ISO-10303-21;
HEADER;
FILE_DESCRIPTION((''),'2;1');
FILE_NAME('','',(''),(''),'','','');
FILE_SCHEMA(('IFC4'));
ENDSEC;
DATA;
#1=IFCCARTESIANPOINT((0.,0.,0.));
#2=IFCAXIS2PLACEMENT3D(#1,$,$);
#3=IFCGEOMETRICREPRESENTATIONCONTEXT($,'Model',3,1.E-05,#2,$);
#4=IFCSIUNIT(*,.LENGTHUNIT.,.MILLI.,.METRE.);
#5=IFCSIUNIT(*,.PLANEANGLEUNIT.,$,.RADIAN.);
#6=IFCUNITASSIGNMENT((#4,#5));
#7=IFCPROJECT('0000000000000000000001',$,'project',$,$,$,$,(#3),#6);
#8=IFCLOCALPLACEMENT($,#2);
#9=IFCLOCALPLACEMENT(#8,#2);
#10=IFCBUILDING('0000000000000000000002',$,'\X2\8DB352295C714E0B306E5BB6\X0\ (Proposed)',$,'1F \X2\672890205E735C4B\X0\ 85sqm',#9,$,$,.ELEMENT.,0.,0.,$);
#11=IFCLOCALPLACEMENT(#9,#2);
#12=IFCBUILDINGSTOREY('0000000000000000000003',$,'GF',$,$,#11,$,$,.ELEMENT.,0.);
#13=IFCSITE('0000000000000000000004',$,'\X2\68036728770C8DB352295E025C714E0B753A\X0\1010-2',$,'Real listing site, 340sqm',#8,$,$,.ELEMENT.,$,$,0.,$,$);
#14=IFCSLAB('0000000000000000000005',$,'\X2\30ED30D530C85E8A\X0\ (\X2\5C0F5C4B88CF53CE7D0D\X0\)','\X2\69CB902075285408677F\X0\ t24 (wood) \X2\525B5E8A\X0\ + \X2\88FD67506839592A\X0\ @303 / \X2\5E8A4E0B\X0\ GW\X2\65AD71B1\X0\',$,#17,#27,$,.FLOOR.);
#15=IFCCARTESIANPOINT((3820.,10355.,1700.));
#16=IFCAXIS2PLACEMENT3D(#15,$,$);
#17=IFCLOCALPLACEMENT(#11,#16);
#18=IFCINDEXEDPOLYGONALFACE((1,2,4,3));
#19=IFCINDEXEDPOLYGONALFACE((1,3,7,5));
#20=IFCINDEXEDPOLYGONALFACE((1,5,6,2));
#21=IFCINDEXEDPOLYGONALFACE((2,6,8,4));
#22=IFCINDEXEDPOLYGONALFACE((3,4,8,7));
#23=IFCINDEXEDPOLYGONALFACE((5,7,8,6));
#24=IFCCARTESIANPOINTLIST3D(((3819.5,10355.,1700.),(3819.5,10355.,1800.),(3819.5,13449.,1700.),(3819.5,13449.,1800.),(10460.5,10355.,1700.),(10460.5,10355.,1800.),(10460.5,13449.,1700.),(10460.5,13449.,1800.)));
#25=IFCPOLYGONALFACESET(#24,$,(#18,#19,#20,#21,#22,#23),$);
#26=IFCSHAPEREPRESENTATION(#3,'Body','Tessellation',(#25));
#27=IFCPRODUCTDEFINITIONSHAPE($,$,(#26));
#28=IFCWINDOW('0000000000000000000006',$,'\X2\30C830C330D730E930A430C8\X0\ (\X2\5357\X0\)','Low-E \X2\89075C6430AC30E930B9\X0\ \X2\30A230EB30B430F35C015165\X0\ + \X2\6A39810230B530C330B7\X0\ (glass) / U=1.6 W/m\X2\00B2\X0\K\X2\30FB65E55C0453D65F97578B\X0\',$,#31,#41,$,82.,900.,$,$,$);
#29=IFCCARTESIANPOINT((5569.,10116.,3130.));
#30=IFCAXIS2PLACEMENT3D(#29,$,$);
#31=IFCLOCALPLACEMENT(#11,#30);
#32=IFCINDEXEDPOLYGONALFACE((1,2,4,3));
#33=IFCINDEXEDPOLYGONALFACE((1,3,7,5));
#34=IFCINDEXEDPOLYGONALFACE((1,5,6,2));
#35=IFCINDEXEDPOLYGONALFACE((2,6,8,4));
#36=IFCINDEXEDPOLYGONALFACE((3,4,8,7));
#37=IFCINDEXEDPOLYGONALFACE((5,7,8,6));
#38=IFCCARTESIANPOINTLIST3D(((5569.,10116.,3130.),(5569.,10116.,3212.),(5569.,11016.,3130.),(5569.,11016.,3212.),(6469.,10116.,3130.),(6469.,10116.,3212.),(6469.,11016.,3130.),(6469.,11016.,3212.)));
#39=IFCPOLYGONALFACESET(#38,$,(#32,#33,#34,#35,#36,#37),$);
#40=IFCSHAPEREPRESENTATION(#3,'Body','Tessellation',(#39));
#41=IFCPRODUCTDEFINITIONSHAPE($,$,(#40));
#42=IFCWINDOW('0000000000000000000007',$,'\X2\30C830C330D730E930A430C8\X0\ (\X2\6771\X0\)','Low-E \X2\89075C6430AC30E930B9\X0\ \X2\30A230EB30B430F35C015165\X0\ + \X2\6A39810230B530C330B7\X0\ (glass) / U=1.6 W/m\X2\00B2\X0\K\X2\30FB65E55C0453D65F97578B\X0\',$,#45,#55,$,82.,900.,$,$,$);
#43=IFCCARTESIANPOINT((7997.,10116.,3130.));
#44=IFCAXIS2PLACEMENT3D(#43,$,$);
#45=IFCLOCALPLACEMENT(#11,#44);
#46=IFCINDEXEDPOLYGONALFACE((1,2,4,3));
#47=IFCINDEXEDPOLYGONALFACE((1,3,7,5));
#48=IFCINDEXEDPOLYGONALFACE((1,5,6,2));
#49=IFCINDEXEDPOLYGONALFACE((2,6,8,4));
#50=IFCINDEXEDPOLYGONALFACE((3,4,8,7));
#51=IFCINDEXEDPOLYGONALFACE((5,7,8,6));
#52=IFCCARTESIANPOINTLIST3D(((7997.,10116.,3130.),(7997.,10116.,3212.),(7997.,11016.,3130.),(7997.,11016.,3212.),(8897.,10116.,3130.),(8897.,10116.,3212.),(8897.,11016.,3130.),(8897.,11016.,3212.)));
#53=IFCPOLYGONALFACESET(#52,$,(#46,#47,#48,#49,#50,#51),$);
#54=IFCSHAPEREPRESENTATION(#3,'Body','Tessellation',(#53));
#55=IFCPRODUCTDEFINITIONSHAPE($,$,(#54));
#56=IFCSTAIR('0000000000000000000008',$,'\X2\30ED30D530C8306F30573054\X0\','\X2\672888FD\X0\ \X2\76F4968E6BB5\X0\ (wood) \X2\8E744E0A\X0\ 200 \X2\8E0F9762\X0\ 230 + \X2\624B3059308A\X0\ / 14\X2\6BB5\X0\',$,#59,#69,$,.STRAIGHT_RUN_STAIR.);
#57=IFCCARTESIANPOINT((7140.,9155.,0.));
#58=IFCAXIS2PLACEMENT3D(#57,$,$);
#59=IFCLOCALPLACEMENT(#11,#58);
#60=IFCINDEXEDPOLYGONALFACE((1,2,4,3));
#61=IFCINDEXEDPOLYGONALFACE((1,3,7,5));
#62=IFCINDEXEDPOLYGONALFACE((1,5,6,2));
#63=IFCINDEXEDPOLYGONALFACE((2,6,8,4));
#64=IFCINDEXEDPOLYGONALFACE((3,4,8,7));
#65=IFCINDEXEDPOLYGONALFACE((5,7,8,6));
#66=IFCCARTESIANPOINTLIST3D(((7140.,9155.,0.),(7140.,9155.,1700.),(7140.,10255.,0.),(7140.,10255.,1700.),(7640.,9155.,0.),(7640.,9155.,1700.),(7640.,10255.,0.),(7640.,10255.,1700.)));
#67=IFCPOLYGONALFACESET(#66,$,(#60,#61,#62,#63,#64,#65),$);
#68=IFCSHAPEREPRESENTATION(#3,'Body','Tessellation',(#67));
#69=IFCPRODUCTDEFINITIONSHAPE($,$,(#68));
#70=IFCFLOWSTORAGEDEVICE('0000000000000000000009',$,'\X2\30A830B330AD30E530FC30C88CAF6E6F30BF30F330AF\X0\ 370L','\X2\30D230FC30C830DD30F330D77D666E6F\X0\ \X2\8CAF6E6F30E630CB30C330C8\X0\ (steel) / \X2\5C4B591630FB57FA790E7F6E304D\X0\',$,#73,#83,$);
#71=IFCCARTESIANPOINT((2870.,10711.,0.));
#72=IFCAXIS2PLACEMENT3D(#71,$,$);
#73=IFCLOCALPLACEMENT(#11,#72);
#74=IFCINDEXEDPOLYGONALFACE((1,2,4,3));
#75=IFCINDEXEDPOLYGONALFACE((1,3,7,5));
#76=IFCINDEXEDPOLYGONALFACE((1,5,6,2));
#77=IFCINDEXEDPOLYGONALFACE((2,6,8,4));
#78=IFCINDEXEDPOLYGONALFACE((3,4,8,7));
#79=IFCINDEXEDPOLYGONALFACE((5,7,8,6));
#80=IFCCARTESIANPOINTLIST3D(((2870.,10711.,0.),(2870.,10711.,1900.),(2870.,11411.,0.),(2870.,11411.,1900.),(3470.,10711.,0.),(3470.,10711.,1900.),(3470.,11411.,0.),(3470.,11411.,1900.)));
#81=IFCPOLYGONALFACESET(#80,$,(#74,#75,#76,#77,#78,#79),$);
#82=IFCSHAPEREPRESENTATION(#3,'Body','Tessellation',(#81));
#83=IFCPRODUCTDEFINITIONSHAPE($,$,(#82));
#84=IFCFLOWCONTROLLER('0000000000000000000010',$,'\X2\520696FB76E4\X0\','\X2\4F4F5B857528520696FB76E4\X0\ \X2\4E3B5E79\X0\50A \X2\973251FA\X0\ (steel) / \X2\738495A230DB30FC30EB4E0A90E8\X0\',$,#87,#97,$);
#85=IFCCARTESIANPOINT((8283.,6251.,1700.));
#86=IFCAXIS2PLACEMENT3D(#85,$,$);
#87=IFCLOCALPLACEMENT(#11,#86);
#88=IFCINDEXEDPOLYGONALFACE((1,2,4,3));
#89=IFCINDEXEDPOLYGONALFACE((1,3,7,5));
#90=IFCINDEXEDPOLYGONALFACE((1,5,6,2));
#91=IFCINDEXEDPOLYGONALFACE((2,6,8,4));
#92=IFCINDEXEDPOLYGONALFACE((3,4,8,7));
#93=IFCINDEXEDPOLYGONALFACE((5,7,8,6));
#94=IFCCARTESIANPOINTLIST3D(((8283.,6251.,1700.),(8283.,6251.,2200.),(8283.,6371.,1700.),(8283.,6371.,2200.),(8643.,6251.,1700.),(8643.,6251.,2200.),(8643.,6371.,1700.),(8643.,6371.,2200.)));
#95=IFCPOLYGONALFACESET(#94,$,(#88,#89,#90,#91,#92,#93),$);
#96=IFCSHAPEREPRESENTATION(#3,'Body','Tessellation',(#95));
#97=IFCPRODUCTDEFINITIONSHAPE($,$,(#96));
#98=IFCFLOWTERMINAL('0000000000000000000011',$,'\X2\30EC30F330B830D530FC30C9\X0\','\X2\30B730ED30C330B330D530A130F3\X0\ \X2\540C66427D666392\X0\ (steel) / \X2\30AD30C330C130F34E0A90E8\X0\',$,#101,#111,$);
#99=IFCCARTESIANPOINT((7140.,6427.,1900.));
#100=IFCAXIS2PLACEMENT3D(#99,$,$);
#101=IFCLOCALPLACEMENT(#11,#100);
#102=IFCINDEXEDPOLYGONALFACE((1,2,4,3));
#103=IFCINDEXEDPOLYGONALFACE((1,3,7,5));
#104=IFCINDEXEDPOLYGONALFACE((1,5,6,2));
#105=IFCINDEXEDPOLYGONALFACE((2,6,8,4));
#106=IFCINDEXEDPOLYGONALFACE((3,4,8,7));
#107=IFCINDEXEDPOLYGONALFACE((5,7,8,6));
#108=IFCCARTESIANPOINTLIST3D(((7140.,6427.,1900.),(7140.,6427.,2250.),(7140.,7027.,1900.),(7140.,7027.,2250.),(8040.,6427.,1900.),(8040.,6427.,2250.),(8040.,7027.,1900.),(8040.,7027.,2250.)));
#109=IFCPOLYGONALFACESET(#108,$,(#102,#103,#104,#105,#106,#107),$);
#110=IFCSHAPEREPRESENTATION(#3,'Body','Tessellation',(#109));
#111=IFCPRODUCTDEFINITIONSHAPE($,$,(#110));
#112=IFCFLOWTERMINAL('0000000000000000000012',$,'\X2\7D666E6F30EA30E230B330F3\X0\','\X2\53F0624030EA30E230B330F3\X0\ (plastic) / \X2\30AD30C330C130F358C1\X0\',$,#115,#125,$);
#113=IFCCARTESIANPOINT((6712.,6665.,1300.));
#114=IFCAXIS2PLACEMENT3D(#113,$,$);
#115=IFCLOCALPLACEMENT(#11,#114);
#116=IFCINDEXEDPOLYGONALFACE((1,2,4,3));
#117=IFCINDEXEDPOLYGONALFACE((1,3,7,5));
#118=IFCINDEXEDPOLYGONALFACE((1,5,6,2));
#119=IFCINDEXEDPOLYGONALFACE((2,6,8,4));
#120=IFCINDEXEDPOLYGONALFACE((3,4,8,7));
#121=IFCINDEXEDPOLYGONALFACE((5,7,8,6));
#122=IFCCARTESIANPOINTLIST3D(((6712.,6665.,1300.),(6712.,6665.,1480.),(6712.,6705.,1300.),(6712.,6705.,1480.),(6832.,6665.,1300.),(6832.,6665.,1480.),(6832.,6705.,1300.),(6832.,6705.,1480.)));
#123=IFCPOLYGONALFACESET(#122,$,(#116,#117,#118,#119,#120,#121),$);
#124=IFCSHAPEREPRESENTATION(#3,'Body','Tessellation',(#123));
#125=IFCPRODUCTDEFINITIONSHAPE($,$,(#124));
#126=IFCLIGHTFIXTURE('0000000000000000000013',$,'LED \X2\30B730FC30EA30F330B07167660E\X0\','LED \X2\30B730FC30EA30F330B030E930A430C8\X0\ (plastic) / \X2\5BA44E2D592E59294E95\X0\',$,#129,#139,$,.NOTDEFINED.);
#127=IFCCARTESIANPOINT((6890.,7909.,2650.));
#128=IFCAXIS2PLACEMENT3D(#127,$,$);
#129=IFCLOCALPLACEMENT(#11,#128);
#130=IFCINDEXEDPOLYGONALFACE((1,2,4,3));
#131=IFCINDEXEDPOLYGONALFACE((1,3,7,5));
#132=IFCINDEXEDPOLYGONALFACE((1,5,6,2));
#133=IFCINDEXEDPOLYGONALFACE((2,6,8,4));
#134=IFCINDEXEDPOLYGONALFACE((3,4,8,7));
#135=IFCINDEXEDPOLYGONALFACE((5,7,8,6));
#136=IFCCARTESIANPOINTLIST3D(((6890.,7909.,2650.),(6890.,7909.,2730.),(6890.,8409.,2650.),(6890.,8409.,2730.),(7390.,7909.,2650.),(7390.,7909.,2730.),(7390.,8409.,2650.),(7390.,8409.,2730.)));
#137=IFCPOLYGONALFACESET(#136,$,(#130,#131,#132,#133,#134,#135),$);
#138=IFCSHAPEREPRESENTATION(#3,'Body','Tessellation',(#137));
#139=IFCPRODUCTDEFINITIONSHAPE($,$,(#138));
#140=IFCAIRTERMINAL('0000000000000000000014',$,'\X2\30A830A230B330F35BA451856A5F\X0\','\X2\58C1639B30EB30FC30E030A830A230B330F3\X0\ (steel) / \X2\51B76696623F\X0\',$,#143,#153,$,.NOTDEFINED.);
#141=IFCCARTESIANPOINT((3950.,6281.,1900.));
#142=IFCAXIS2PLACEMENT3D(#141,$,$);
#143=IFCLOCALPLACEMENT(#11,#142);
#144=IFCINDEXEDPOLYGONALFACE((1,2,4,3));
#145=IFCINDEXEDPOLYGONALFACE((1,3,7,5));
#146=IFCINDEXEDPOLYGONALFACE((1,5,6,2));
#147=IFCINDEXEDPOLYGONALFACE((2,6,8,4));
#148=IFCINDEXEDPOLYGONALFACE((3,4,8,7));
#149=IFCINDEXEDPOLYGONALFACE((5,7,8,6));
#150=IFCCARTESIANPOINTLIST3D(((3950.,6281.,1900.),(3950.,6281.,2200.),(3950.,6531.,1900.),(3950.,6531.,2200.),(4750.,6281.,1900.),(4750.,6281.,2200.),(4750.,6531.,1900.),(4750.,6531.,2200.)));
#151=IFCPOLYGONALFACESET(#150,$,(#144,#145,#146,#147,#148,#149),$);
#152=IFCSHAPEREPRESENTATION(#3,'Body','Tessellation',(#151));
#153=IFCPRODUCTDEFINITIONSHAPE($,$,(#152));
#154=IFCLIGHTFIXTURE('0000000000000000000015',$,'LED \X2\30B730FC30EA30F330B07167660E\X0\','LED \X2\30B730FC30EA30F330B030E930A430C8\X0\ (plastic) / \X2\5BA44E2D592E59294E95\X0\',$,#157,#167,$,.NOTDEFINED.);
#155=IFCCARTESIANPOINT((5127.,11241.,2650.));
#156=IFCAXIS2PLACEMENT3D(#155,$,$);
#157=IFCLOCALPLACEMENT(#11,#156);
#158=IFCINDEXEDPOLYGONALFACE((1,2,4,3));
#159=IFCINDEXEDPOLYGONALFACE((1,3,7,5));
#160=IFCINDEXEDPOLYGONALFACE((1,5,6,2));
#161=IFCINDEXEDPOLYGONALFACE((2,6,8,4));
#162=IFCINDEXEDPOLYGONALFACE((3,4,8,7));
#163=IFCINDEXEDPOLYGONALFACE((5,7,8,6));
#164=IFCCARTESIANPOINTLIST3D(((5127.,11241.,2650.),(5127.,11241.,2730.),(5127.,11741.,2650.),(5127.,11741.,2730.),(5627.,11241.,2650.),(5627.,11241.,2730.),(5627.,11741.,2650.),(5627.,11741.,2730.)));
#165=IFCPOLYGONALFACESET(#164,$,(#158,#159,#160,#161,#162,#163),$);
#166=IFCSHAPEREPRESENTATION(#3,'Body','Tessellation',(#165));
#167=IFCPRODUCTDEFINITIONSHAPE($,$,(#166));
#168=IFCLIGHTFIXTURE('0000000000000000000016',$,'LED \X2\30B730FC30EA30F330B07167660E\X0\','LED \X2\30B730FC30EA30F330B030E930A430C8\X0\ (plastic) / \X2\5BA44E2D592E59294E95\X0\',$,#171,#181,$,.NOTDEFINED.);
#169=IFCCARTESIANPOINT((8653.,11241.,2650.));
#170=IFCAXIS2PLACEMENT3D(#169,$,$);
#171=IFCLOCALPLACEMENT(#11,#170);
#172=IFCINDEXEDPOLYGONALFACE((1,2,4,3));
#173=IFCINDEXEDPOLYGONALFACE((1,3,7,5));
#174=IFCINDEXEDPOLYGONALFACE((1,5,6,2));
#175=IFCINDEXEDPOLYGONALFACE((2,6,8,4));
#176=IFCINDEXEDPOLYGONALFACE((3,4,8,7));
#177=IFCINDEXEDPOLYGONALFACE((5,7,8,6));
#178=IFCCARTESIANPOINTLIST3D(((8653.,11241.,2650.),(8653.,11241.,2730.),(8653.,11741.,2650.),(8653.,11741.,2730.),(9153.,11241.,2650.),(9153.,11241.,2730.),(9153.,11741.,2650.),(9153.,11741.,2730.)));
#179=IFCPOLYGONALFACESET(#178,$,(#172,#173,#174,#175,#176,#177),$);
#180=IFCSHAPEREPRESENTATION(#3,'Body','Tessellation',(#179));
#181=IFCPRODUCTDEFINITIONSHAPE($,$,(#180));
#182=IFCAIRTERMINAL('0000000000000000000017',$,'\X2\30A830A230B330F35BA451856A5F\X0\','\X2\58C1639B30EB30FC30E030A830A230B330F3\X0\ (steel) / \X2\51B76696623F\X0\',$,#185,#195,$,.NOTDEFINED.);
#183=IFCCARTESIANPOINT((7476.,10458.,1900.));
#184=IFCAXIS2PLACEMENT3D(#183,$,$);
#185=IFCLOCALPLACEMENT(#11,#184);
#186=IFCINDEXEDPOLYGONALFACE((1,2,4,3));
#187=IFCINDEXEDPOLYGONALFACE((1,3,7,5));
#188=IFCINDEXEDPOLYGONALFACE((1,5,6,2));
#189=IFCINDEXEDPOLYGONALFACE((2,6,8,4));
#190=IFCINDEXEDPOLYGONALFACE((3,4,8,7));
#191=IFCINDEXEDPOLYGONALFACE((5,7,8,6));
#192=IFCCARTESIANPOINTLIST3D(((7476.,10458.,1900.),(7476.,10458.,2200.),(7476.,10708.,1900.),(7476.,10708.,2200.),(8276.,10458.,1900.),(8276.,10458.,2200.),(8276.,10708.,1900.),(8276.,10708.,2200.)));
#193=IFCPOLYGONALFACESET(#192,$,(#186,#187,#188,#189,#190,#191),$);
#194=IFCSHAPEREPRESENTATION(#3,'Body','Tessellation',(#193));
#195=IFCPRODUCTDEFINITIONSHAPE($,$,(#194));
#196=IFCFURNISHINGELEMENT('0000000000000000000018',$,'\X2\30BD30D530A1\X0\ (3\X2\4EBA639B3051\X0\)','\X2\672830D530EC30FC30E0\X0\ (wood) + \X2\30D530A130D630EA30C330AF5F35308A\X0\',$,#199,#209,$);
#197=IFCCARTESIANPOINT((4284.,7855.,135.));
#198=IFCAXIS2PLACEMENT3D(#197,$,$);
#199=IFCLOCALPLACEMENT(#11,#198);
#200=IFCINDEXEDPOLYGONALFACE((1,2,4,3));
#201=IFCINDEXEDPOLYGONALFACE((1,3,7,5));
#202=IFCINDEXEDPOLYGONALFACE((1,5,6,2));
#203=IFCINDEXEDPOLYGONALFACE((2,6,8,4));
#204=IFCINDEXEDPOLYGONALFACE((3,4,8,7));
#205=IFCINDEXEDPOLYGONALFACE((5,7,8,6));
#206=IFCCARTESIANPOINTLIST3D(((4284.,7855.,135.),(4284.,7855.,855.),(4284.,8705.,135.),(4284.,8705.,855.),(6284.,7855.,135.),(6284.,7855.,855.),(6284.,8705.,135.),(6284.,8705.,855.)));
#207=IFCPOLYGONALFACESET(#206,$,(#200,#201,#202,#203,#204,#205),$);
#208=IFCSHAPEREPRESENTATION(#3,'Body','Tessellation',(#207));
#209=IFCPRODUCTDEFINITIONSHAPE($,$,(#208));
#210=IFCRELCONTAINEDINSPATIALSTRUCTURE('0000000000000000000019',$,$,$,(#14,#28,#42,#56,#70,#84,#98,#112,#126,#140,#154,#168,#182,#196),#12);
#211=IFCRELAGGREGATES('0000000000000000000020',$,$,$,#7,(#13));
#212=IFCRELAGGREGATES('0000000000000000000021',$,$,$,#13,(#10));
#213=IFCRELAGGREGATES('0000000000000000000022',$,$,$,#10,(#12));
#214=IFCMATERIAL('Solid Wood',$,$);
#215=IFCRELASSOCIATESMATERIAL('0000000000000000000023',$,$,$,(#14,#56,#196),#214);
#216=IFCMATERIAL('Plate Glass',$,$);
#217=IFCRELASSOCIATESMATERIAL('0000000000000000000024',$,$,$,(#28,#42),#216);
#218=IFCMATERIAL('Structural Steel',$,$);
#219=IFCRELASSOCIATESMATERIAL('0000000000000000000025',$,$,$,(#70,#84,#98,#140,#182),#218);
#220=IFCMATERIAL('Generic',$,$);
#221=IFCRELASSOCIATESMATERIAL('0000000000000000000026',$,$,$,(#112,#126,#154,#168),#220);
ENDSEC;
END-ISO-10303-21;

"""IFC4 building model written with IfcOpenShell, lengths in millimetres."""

from ifc_helpers import new_model, si_unit, frame, frame_2d, origin, place, context, project, spatial, rectangle, extrude, material, element, save


model = new_model("IFC4")

# Units and contexts
model_context = context("Model", 3, precision=1e-05, world=origin())
ifc_project = project(units=[si_unit("LENGTHUNIT", "METRE", prefix="MILLI"), si_unit("PLANEANGLEUNIT", "RADIAN")], contexts=[model_context])

# Site, building, storey
site_placement = place(None, origin())
site = spatial("IfcSite", under=ifc_project, at=site_placement, Name="栃木県足利市山下町1010-2", ObjectType="Real listing site, 340sqm", CompositionType="ELEMENT", RefElevation=0.0)
building_placement = place(site_placement, origin())
building = spatial("IfcBuilding", under=site, at=building_placement, Name="足利山下の家 (Proposed)", ObjectType="1F 木造平屋 85sqm", CompositionType="ELEMENT", ElevationOfRefHeight=0.0, ElevationOfTerrain=0.0)
storey_placement = place(building_placement, origin())
storey = spatial("IfcBuildingStorey", under=building, at=storey_placement, Name="GF", CompositionType="ELEMENT", Elevation=0.0)

# Shared definitions
ifc_material_1 = material(Name="Solid Wood")

# Slab
slab_placement = place(storey_placement, frame((3820.0, 10355.0, 1700.0)))
element("IfcSlab", 1, at=slab_placement, inside=storey, material=ifc_material_1, Name="ロフト床 (小屋裏収納)", Description="構造用合板 t24 (wood) 剛床 + 製材根太 @303 / 床下 GW断熱", PredefinedType="FLOOR", context=model_context, shape_type="SweptSolid", body=[
    extrude(rectangle(XDim=6641.0, YDim=3094.0, at=frame_2d((3320.0, 1547.0))), frame((3820.0, 10355.0, 1700.0)), (0.0, 0.0, 1.0), 100.0),
])

# Windows
ifc_material_2 = material(Name="Plate Glass")
window_1_placement = place(storey_placement, frame((5569.0, 10116.0, 3130.0)))
element("IfcWindow", 2, at=window_1_placement, inside=storey, material=ifc_material_2, Name="トップライト (南)", Description="Low-E 複層ガラス アルゴン封入 + 樹脂サッシ (glass) / U=1.6 W/m²K・日射取得型", OverallHeight=82.0, OverallWidth=900.0, context=model_context, shape_type="SweptSolid", body=[
    extrude(rectangle(XDim=900.0, YDim=900.0, at=frame_2d((450.0, 450.0))), frame((5569.0, 10116.0, 3130.0)), (0.0, 0.0, 1.0), 82.0),
])
window_2_placement = place(storey_placement, frame((7997.0, 10116.0, 3130.0)))
element("IfcWindow", 3, at=window_2_placement, inside=storey, material=ifc_material_2, Name="トップライト (東)", Description="Low-E 複層ガラス アルゴン封入 + 樹脂サッシ (glass) / U=1.6 W/m²K・日射取得型", OverallHeight=82.0, OverallWidth=900.0, context=model_context, shape_type="SweptSolid", body=[
    extrude(rectangle(XDim=900.0, YDim=900.0, at=frame_2d((450.0, 450.0))), frame((7997.0, 10116.0, 3130.0)), (0.0, 0.0, 1.0), 82.0),
])

# Stair
stair_placement = place(storey_placement, frame((7140.0, 9155.0, 0.0)))
element("IfcStair", 4, at=stair_placement, inside=storey, material=ifc_material_1, Name="ロフトはしご", Description="木製 直階段 (wood) 蹴上 200 踏面 230 + 手すり / 14段", PredefinedType="STRAIGHT_RUN_STAIR", context=model_context, shape_type="SweptSolid", body=[
    extrude(rectangle(XDim=500.0, YDim=1100.0, at=frame_2d((250.0, 550.0))), frame((7140.0, 9155.0, 0.0)), (0.0, 0.0, 1.0), 1700.0),
])

# Flow storage device
ifc_material_3 = material(Name="Structural Steel")
flow_storage_device_placement = place(storey_placement, frame((2870.0, 10711.0, 0.0)))
element("IfcFlowStorageDevice", 5, at=flow_storage_device_placement, inside=storey, material=ifc_material_3, Name="エコキュート貯湯タンク 370L", Description="ヒートポンプ給湯 貯湯ユニット (steel) / 屋外・基礎置き", context=model_context, shape_type="SweptSolid", body=[
    extrude(rectangle(XDim=600.0, YDim=700.0, at=frame_2d((300.0, 350.0))), frame((2870.0, 10711.0, 0.0)), (0.0, 0.0, 1.0), 1900.0),
])

# Flow controller
flow_controller_placement = place(storey_placement, frame((8283.0, 6251.0, 1700.0)))
element("IfcFlowController", 6, at=flow_controller_placement, inside=storey, material=ifc_material_3, Name="分電盤", Description="住宅用分電盤 主幹50A 露出 (steel) / 玄関ホール上部", context=model_context, shape_type="SweptSolid", body=[
    extrude(rectangle(XDim=360.0, YDim=120.0, at=frame_2d((180.0, 60.0))), frame((8283.0, 6251.0, 1700.0)), (0.0, 0.0, 1.0), 500.0),
])

# Flow terminals
flow_terminal_1_placement = place(storey_placement, frame((7140.0, 6427.0, 1900.0)))
element("IfcFlowTerminal", 7, at=flow_terminal_1_placement, inside=storey, material=ifc_material_3, Name="レンジフード", Description="シロッコファン 同時給排 (steel) / キッチン上部", context=model_context, shape_type="SweptSolid", body=[
    extrude(rectangle(XDim=900.0, YDim=600.0, at=frame_2d((450.0, 300.0))), frame((7140.0, 6427.0, 1900.0)), (0.0, 0.0, 1.0), 350.0),
])
ifc_material_4 = material(Name="Generic")
flow_terminal_2_placement = place(storey_placement, frame((6712.0, 6665.0, 1300.0)))
element("IfcFlowTerminal", 8, at=flow_terminal_2_placement, inside=storey, material=ifc_material_4, Name="給湯リモコン", Description="台所リモコン (plastic) / キッチン壁", context=model_context, shape_type="SweptSolid", body=[
    extrude(rectangle(XDim=120.0, YDim=40.0, at=frame_2d((60.0, 20.0))), frame((6712.0, 6665.0, 1300.0)), (0.0, 0.0, 1.0), 180.0),
])

# Light fixture
light_fixture_1_placement = place(storey_placement, frame((6890.0, 7909.0, 2650.0)))
element("IfcLightFixture", 9, at=light_fixture_1_placement, inside=storey, material=ifc_material_4, Name="LED シーリング照明", Description="LED シーリングライト (plastic) / 室中央天井", PredefinedType="NOTDEFINED", context=model_context, shape_type="SweptSolid", body=[
    extrude(rectangle(XDim=500.0, YDim=500.0, at=frame_2d((250.0, 250.0))), frame((6890.0, 7909.0, 2650.0)), (0.0, 0.0, 1.0), 80.0),
])

# Air terminal
air_terminal_1_placement = place(storey_placement, frame((3950.0, 6281.0, 1900.0)))
element("IfcAirTerminal", 10, at=air_terminal_1_placement, inside=storey, material=ifc_material_3, Name="エアコン室内機", Description="壁掛ルームエアコン (steel) / 冷暖房", PredefinedType="NOTDEFINED", context=model_context, shape_type="SweptSolid", body=[
    extrude(rectangle(XDim=800.0, YDim=250.0, at=frame_2d((400.0, 125.0))), frame((3950.0, 6281.0, 1900.0)), (0.0, 0.0, 1.0), 300.0),
])

# Light fixtures
light_fixture_2_placement = place(storey_placement, frame((5127.0, 11241.0, 2650.0)))
element("IfcLightFixture", 11, at=light_fixture_2_placement, inside=storey, material=ifc_material_4, Name="LED シーリング照明", Description="LED シーリングライト (plastic) / 室中央天井", PredefinedType="NOTDEFINED", context=model_context, shape_type="SweptSolid", body=[
    extrude(rectangle(XDim=500.0, YDim=500.0, at=frame_2d((250.0, 250.0))), frame((5127.0, 11241.0, 2650.0)), (0.0, 0.0, 1.0), 80.0),
])
light_fixture_3_placement = place(storey_placement, frame((8653.0, 11241.0, 2650.0)))
element("IfcLightFixture", 12, at=light_fixture_3_placement, inside=storey, material=ifc_material_4, Name="LED シーリング照明", Description="LED シーリングライト (plastic) / 室中央天井", PredefinedType="NOTDEFINED", context=model_context, shape_type="SweptSolid", body=[
    extrude(rectangle(XDim=500.0, YDim=500.0, at=frame_2d((250.0, 250.0))), frame((8653.0, 11241.0, 2650.0)), (0.0, 0.0, 1.0), 80.0),
])

# Air terminal
air_terminal_2_placement = place(storey_placement, frame((7476.0, 10458.0, 1900.0)))
element("IfcAirTerminal", 13, at=air_terminal_2_placement, inside=storey, material=ifc_material_3, Name="エアコン室内機", Description="壁掛ルームエアコン (steel) / 冷暖房", PredefinedType="NOTDEFINED", context=model_context, shape_type="SweptSolid", body=[
    extrude(rectangle(XDim=800.0, YDim=250.0, at=frame_2d((400.0, 125.0))), frame((7476.0, 10458.0, 1900.0)), (0.0, 0.0, 1.0), 300.0),
])

# Furnishing element
furnishing_1_placement = place(storey_placement, frame((4284.0, 7855.0, 135.0)))
element("IfcFurnishingElement", 14, at=furnishing_1_placement, inside=storey, material=ifc_material_1, Name="ソファ (3人掛け)", Description="木フレーム (wood) + ファブリック張り", context=model_context, shape_type="SweptSolid", body=[
    extrude(rectangle(XDim=2000.0, YDim=850.0, at=frame_2d((1000.0, 425.0))), frame((4284.0, 7855.0, 135.0)), (0.0, 0.0, 1.0), 720.0),
])

save(model, "model.ifc")
